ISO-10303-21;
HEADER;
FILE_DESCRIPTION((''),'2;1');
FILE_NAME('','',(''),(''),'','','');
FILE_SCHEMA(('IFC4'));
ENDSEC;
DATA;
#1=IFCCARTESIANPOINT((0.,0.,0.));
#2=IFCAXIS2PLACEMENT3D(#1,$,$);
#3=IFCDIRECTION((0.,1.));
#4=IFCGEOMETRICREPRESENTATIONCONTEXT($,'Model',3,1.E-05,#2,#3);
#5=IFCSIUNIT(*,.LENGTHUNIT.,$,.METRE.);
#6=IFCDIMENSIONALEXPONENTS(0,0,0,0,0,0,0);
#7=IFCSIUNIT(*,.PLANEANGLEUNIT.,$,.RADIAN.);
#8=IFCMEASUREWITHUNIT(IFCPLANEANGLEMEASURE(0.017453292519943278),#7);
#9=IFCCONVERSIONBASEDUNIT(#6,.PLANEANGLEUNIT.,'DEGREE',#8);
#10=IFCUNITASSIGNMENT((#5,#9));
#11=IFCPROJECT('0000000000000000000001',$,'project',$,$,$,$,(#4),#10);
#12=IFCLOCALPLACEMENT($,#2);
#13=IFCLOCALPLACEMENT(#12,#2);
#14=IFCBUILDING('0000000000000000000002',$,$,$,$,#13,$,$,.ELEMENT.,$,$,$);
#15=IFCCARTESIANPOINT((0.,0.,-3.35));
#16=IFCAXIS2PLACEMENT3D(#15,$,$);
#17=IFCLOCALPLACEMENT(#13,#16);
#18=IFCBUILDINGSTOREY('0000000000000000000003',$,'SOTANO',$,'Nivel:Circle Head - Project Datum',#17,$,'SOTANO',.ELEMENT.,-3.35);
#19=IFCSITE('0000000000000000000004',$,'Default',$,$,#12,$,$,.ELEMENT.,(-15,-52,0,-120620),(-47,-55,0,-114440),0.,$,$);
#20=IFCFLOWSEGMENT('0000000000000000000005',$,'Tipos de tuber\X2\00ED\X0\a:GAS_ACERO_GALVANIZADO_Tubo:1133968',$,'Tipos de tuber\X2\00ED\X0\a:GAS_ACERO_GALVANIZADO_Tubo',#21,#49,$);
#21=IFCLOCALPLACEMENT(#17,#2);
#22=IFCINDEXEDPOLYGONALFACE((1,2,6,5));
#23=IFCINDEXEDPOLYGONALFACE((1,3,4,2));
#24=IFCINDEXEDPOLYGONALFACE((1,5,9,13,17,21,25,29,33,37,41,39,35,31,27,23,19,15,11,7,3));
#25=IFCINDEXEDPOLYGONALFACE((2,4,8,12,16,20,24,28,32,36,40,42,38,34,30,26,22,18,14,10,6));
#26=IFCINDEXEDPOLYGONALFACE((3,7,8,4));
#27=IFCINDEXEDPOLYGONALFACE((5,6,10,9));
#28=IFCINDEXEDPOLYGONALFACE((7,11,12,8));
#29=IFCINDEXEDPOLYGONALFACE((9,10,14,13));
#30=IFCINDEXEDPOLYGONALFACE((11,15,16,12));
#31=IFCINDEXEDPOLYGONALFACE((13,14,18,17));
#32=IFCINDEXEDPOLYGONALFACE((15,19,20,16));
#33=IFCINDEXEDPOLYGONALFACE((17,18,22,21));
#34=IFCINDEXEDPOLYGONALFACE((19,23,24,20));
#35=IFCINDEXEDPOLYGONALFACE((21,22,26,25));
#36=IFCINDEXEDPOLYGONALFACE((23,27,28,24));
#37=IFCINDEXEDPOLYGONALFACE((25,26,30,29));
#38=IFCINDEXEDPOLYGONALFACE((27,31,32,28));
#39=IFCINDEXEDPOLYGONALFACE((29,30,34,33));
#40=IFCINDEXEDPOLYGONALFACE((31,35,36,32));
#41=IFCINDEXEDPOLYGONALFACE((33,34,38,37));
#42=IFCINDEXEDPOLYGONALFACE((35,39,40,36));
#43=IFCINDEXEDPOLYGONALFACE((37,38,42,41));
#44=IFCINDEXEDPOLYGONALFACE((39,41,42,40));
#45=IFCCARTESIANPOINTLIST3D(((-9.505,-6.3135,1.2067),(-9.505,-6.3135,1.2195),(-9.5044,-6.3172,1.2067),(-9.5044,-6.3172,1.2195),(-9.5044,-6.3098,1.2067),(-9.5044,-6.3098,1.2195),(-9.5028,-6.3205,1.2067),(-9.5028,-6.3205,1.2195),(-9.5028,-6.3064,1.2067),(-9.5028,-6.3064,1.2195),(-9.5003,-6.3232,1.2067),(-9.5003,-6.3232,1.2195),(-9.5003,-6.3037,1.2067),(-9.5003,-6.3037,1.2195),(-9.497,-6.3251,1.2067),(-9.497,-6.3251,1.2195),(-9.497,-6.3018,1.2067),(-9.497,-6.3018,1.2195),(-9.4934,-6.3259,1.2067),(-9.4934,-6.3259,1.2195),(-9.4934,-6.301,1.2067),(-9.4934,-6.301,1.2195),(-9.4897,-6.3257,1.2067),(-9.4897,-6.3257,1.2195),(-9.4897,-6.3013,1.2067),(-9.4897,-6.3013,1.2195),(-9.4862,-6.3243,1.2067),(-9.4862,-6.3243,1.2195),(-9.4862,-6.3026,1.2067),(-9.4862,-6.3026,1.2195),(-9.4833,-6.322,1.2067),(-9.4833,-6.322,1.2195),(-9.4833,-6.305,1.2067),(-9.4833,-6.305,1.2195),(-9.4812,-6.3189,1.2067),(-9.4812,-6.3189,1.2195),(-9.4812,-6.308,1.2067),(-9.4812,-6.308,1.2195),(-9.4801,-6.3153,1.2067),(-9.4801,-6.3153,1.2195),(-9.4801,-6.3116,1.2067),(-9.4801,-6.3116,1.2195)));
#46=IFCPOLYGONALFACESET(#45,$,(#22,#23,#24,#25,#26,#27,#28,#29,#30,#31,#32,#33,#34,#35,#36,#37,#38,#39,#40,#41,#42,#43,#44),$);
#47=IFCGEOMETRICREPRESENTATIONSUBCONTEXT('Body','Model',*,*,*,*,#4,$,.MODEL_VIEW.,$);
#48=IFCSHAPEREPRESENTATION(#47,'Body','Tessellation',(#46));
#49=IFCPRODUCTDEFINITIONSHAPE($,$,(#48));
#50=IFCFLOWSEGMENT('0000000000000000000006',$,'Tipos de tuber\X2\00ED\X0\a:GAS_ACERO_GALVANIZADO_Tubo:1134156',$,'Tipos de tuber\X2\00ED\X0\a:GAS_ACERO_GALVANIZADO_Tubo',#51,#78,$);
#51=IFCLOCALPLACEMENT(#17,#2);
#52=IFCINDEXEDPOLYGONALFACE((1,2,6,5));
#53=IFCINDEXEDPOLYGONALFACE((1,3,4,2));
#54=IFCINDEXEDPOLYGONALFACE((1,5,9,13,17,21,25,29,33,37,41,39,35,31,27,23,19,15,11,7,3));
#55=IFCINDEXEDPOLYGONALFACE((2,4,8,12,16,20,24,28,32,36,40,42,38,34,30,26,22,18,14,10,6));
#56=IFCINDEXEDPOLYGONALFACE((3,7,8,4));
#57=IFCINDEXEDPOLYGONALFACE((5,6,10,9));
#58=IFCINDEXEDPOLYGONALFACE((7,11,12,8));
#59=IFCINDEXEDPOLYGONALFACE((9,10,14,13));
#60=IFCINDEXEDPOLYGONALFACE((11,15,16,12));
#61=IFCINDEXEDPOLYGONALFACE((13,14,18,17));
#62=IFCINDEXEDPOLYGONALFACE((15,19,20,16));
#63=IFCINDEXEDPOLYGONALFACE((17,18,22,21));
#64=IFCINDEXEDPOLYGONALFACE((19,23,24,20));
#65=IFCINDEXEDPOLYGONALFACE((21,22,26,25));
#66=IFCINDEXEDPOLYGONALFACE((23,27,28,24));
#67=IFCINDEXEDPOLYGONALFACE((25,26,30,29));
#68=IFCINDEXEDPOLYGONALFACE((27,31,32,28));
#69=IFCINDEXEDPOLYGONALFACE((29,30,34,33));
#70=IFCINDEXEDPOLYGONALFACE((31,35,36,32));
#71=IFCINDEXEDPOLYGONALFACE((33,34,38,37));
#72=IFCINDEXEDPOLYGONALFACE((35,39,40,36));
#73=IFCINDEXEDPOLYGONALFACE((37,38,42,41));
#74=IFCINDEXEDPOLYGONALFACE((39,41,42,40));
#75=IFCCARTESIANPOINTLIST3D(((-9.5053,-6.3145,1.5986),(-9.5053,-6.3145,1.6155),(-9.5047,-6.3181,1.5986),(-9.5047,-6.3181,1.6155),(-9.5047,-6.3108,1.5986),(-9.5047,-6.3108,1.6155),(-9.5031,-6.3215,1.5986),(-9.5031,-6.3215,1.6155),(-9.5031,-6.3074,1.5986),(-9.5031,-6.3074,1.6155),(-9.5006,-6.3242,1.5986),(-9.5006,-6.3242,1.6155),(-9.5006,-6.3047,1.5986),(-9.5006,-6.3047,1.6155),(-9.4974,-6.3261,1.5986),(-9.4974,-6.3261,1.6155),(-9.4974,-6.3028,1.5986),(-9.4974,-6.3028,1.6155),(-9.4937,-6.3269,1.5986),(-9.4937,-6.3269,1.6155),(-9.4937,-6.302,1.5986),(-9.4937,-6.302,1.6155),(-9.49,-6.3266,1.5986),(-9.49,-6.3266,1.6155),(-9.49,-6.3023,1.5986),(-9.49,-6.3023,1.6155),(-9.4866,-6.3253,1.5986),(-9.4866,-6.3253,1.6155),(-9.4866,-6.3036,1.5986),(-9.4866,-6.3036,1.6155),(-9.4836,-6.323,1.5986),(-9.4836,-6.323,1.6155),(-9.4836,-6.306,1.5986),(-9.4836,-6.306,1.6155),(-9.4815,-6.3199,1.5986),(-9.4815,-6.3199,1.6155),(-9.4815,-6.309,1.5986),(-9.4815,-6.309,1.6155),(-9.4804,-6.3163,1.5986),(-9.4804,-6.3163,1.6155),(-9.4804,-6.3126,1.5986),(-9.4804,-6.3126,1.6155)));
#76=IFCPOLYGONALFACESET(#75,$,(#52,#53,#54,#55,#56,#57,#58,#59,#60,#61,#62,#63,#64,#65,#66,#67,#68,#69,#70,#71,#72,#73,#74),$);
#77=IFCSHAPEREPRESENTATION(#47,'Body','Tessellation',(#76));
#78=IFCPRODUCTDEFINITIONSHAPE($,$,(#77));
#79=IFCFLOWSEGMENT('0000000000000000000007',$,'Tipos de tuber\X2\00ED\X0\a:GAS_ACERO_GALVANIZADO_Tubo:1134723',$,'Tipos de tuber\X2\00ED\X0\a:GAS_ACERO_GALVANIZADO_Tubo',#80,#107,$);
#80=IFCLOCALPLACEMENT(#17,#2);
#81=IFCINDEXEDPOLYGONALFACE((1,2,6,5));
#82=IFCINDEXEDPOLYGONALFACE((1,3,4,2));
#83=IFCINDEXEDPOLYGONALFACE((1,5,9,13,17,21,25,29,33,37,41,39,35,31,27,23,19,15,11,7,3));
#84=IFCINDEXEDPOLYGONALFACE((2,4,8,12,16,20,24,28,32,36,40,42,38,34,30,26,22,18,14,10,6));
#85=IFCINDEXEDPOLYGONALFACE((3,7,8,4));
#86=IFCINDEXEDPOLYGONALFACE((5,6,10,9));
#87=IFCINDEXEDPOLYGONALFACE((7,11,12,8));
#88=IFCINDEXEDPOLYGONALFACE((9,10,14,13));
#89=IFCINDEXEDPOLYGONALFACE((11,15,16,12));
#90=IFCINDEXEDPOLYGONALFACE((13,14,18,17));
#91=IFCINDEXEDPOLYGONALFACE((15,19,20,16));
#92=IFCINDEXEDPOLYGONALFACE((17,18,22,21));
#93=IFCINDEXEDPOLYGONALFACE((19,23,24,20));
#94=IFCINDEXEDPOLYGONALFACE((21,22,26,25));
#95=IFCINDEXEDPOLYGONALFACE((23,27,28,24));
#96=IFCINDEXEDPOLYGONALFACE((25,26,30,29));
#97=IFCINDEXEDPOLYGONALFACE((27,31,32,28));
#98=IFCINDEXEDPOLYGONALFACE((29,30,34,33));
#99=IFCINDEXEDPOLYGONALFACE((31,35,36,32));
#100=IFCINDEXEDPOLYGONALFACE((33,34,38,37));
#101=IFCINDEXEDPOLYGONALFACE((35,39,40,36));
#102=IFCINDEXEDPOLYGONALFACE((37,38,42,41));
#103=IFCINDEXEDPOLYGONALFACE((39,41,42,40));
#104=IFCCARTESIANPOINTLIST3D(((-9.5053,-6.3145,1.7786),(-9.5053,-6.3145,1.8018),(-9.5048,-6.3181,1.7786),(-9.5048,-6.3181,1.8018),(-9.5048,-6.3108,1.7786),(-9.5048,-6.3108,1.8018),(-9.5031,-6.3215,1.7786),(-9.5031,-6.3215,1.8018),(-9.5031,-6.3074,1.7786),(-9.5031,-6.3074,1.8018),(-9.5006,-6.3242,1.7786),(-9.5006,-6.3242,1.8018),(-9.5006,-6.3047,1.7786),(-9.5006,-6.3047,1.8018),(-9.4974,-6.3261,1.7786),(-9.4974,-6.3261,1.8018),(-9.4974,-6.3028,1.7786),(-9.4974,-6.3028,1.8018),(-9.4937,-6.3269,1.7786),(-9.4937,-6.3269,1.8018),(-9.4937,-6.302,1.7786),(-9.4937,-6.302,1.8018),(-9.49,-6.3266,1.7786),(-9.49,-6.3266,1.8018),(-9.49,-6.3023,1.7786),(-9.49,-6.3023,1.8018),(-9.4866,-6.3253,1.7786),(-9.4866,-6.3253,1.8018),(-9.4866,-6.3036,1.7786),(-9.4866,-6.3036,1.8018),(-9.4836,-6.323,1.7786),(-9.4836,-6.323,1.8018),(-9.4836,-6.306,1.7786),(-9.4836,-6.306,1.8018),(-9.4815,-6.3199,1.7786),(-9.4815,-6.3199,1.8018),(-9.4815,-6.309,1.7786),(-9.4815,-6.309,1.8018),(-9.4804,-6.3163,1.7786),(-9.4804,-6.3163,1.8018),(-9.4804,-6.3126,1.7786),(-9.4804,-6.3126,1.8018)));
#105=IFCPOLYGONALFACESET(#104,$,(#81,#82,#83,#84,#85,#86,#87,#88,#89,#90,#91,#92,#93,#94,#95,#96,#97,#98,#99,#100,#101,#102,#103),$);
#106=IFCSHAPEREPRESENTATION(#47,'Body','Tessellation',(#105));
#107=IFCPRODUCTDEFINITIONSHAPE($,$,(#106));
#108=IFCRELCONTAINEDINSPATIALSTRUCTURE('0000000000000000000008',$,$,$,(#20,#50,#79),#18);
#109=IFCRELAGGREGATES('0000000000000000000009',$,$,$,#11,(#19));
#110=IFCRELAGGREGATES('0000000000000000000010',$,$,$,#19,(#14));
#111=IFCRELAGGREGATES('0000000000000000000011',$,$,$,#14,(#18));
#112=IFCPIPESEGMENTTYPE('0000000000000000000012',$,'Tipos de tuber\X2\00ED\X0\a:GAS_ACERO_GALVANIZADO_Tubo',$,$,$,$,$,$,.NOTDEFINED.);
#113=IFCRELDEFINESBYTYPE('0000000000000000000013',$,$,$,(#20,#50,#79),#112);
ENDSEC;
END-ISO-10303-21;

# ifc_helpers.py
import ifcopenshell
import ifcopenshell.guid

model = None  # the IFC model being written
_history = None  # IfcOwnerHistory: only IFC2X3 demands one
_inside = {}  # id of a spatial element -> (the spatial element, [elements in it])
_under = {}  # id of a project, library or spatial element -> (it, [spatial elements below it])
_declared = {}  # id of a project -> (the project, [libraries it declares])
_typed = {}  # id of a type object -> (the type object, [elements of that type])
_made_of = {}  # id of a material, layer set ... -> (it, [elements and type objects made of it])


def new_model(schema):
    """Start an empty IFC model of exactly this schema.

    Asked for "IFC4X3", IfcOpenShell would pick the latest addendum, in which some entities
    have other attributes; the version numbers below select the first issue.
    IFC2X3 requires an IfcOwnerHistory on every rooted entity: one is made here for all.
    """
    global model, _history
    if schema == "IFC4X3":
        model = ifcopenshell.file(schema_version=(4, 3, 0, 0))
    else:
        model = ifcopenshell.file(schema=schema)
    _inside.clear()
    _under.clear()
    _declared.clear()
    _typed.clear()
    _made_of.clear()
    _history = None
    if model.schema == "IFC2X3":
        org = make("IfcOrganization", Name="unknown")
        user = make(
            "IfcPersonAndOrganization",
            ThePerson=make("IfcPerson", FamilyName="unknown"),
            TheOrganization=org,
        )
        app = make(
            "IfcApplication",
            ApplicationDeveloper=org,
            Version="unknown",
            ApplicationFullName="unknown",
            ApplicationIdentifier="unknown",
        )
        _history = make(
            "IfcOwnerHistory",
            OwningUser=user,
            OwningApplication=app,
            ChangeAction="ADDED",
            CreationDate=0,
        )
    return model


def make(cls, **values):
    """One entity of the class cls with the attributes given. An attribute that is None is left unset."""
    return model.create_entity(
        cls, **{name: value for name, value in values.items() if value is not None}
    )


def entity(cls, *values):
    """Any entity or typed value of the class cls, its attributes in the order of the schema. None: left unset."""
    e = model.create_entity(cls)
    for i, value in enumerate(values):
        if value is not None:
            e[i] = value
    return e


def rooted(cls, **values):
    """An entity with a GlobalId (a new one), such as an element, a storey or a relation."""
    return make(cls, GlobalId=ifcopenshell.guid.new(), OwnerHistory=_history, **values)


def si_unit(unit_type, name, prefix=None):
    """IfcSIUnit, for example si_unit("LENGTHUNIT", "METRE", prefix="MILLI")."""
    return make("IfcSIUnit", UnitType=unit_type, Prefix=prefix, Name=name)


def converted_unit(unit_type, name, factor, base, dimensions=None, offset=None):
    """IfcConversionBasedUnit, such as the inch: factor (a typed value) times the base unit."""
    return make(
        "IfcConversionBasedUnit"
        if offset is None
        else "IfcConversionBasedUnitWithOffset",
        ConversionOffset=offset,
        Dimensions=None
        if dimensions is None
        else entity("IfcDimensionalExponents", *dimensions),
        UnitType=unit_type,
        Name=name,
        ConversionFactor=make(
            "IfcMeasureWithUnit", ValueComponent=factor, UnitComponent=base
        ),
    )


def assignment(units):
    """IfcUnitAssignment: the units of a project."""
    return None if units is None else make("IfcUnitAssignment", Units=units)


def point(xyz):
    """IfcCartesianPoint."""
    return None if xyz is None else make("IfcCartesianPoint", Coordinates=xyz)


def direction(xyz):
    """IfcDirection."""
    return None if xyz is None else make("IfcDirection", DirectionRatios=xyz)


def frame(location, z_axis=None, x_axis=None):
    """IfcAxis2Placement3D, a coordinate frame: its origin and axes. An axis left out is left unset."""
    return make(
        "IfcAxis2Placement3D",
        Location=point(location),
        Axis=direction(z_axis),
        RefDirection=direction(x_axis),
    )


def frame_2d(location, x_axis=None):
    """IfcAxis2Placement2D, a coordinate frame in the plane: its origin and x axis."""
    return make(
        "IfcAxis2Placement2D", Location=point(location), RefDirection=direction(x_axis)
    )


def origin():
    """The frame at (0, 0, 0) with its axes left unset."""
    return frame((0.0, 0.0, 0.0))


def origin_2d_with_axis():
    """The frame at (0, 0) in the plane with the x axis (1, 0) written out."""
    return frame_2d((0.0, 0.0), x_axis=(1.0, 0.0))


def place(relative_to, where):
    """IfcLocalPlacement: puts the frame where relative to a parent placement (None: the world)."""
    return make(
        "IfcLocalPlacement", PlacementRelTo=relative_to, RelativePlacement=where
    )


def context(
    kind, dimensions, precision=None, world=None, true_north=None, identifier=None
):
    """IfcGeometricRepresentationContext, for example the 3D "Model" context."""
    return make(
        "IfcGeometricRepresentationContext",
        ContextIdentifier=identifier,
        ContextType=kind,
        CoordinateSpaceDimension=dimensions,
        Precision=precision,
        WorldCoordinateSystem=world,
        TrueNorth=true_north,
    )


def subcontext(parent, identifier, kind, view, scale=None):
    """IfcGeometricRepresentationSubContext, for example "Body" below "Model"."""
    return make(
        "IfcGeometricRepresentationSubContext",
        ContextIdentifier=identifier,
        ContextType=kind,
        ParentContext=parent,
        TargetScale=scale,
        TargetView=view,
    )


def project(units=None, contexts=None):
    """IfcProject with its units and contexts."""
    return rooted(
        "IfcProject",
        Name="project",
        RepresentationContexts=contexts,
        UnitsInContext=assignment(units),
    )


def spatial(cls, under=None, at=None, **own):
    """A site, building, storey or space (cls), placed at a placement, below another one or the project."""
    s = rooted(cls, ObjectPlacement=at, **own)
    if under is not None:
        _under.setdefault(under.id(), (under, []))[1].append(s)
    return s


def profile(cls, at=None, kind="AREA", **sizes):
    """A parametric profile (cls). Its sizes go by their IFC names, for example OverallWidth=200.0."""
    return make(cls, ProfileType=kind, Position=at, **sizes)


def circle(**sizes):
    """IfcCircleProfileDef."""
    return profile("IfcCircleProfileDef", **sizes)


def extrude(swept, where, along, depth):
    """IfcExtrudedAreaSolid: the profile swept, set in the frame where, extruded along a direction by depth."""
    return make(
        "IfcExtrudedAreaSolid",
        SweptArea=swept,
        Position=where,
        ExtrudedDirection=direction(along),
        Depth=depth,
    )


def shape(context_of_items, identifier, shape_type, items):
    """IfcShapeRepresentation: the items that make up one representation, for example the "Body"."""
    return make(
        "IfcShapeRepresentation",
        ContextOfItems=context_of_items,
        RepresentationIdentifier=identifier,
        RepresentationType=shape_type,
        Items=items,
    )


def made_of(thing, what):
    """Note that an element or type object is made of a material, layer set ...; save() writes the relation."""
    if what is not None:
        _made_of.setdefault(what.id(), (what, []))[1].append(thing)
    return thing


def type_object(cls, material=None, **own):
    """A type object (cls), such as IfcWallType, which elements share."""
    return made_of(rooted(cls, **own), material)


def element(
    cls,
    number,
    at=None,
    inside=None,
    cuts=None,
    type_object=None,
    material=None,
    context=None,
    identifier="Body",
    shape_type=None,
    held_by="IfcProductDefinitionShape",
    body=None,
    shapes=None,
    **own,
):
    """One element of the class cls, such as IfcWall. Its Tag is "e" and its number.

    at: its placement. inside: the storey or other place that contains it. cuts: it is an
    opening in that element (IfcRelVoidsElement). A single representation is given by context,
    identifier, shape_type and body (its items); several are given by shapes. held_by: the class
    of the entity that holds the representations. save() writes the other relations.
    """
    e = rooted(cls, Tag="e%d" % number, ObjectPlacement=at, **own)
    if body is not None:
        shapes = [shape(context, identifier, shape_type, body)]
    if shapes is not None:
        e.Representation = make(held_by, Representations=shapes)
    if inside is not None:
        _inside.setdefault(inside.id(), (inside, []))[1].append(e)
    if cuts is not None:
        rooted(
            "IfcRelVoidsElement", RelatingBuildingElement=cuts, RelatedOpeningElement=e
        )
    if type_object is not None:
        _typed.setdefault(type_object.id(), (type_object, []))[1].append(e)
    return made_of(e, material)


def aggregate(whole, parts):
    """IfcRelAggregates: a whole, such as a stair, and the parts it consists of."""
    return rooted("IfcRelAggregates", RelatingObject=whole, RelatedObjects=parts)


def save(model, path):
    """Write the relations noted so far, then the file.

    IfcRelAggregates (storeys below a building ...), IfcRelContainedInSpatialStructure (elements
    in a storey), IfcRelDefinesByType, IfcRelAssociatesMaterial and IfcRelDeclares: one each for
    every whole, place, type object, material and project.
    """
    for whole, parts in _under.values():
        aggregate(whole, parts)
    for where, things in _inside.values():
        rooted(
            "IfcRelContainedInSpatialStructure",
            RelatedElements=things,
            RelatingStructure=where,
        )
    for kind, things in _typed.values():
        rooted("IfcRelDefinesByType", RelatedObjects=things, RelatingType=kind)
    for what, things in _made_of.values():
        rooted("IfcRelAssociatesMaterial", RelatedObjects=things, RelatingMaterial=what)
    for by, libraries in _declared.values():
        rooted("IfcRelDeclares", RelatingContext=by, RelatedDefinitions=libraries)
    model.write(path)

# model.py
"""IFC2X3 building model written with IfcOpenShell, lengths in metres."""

from ifc_helpers import new_model, entity, si_unit, converted_unit, direction, frame, frame_2d, origin, origin_2d_with_axis, place, context, subcontext, project, spatial, circle, extrude, type_object, element, save


model = new_model("IFC2X3")

# Units and contexts
model_context = context("Model", 3, precision=1e-05, world=origin(), true_north=direction((0.0, 1.0)))
body_context = subcontext(model_context, "Body", "Model", "MODEL_VIEW")
ifc_project = project(units=[si_unit("LENGTHUNIT", "METRE"), converted_unit("PLANEANGLEUNIT", "DEGREE", entity("IfcPlaneAngleMeasure", 0.017453292519943278), si_unit("PLANEANGLEUNIT", "RADIAN"), dimensions=[0, 0, 0, 0, 0, 0, 0])], contexts=[model_context])

# Site, building, storey
site_placement = place(None, origin())
site = spatial("IfcSite", under=ifc_project, at=site_placement, Name="Default", CompositionType="ELEMENT", RefLatitude=(-15, -52, 0, -120620), RefLongitude=(-47, -55, 0, -114440), RefElevation=0.0)
building_placement = place(site_placement, origin())
building = spatial("IfcBuilding", under=site, at=building_placement, CompositionType="ELEMENT")
storey_placement = place(building_placement, frame((0.0, 0.0, -3.35)))
storey = spatial("IfcBuildingStorey", under=building, at=storey_placement, Name="SOTANO", ObjectType="Nivel:Circle Head - Project Datum", LongName="SOTANO", CompositionType="ELEMENT", Elevation=-3.35)

# Flow segments
pipe_segment_type_1 = type_object("IfcPipeSegmentType", Name="Tipos de tubería:GAS_ACERO_GALVANIZADO_Tubo", PredefinedType="NOTDEFINED")
flow_segment_1_placement = place(storey_placement, origin())
element("IfcFlowSegment", 1, at=flow_segment_1_placement, inside=storey, type_object=pipe_segment_type_1, Name="Tipos de tubería:GAS_ACERO_GALVANIZADO_Tubo:1133968", ObjectType="Tipos de tubería:GAS_ACERO_GALVANIZADO_Tubo", context=body_context, shape_type="SweptSolid", body=[
    extrude(circle(Radius=0.0125, at=frame_2d((0.0, 0.0), x_axis=(1.0, 0.0))), frame((-9.4925, -6.3135, 1.2067), z_axis=(-0.000015, 0.0, 1.0), x_axis=(-1.0, 0.0, -0.000015)), (0.0, 0.0, 1.0), 0.0127),
])
flow_segment_2_placement = place(storey_placement, origin())
element("IfcFlowSegment", 2, at=flow_segment_2_placement, inside=storey, type_object=pipe_segment_type_1, Name="Tipos de tubería:GAS_ACERO_GALVANIZADO_Tubo:1134156", ObjectType="Tipos de tubería:GAS_ACERO_GALVANIZADO_Tubo", context=body_context, shape_type="SweptSolid", body=[
    extrude(circle(Radius=0.0125, at=origin_2d_with_axis()), frame((-9.4928, -6.3145, 1.5986), z_axis=(-0.000192, 0.0, 1.0), x_axis=(-1.0, 0.0, -0.000192)), (0.0, 0.0, 1.0), 0.0169),
])
flow_segment_3_placement = place(storey_placement, origin())
element("IfcFlowSegment", 3, at=flow_segment_3_placement, inside=storey, type_object=pipe_segment_type_1, Name="Tipos de tubería:GAS_ACERO_GALVANIZADO_Tubo:1134723", ObjectType="Tipos de tubería:GAS_ACERO_GALVANIZADO_Tubo", context=body_context, shape_type="SweptSolid", body=[
    extrude(circle(Radius=0.0125, at=origin_2d_with_axis()), frame((-9.4928, -6.3145, 1.7786), z_axis=(0.000013, 0.0, 1.0), x_axis=(-1.0, 0.0, 0.000013)), (0.0, 0.0, 1.0), 0.0232),
])

save(model, "model.ifc")
